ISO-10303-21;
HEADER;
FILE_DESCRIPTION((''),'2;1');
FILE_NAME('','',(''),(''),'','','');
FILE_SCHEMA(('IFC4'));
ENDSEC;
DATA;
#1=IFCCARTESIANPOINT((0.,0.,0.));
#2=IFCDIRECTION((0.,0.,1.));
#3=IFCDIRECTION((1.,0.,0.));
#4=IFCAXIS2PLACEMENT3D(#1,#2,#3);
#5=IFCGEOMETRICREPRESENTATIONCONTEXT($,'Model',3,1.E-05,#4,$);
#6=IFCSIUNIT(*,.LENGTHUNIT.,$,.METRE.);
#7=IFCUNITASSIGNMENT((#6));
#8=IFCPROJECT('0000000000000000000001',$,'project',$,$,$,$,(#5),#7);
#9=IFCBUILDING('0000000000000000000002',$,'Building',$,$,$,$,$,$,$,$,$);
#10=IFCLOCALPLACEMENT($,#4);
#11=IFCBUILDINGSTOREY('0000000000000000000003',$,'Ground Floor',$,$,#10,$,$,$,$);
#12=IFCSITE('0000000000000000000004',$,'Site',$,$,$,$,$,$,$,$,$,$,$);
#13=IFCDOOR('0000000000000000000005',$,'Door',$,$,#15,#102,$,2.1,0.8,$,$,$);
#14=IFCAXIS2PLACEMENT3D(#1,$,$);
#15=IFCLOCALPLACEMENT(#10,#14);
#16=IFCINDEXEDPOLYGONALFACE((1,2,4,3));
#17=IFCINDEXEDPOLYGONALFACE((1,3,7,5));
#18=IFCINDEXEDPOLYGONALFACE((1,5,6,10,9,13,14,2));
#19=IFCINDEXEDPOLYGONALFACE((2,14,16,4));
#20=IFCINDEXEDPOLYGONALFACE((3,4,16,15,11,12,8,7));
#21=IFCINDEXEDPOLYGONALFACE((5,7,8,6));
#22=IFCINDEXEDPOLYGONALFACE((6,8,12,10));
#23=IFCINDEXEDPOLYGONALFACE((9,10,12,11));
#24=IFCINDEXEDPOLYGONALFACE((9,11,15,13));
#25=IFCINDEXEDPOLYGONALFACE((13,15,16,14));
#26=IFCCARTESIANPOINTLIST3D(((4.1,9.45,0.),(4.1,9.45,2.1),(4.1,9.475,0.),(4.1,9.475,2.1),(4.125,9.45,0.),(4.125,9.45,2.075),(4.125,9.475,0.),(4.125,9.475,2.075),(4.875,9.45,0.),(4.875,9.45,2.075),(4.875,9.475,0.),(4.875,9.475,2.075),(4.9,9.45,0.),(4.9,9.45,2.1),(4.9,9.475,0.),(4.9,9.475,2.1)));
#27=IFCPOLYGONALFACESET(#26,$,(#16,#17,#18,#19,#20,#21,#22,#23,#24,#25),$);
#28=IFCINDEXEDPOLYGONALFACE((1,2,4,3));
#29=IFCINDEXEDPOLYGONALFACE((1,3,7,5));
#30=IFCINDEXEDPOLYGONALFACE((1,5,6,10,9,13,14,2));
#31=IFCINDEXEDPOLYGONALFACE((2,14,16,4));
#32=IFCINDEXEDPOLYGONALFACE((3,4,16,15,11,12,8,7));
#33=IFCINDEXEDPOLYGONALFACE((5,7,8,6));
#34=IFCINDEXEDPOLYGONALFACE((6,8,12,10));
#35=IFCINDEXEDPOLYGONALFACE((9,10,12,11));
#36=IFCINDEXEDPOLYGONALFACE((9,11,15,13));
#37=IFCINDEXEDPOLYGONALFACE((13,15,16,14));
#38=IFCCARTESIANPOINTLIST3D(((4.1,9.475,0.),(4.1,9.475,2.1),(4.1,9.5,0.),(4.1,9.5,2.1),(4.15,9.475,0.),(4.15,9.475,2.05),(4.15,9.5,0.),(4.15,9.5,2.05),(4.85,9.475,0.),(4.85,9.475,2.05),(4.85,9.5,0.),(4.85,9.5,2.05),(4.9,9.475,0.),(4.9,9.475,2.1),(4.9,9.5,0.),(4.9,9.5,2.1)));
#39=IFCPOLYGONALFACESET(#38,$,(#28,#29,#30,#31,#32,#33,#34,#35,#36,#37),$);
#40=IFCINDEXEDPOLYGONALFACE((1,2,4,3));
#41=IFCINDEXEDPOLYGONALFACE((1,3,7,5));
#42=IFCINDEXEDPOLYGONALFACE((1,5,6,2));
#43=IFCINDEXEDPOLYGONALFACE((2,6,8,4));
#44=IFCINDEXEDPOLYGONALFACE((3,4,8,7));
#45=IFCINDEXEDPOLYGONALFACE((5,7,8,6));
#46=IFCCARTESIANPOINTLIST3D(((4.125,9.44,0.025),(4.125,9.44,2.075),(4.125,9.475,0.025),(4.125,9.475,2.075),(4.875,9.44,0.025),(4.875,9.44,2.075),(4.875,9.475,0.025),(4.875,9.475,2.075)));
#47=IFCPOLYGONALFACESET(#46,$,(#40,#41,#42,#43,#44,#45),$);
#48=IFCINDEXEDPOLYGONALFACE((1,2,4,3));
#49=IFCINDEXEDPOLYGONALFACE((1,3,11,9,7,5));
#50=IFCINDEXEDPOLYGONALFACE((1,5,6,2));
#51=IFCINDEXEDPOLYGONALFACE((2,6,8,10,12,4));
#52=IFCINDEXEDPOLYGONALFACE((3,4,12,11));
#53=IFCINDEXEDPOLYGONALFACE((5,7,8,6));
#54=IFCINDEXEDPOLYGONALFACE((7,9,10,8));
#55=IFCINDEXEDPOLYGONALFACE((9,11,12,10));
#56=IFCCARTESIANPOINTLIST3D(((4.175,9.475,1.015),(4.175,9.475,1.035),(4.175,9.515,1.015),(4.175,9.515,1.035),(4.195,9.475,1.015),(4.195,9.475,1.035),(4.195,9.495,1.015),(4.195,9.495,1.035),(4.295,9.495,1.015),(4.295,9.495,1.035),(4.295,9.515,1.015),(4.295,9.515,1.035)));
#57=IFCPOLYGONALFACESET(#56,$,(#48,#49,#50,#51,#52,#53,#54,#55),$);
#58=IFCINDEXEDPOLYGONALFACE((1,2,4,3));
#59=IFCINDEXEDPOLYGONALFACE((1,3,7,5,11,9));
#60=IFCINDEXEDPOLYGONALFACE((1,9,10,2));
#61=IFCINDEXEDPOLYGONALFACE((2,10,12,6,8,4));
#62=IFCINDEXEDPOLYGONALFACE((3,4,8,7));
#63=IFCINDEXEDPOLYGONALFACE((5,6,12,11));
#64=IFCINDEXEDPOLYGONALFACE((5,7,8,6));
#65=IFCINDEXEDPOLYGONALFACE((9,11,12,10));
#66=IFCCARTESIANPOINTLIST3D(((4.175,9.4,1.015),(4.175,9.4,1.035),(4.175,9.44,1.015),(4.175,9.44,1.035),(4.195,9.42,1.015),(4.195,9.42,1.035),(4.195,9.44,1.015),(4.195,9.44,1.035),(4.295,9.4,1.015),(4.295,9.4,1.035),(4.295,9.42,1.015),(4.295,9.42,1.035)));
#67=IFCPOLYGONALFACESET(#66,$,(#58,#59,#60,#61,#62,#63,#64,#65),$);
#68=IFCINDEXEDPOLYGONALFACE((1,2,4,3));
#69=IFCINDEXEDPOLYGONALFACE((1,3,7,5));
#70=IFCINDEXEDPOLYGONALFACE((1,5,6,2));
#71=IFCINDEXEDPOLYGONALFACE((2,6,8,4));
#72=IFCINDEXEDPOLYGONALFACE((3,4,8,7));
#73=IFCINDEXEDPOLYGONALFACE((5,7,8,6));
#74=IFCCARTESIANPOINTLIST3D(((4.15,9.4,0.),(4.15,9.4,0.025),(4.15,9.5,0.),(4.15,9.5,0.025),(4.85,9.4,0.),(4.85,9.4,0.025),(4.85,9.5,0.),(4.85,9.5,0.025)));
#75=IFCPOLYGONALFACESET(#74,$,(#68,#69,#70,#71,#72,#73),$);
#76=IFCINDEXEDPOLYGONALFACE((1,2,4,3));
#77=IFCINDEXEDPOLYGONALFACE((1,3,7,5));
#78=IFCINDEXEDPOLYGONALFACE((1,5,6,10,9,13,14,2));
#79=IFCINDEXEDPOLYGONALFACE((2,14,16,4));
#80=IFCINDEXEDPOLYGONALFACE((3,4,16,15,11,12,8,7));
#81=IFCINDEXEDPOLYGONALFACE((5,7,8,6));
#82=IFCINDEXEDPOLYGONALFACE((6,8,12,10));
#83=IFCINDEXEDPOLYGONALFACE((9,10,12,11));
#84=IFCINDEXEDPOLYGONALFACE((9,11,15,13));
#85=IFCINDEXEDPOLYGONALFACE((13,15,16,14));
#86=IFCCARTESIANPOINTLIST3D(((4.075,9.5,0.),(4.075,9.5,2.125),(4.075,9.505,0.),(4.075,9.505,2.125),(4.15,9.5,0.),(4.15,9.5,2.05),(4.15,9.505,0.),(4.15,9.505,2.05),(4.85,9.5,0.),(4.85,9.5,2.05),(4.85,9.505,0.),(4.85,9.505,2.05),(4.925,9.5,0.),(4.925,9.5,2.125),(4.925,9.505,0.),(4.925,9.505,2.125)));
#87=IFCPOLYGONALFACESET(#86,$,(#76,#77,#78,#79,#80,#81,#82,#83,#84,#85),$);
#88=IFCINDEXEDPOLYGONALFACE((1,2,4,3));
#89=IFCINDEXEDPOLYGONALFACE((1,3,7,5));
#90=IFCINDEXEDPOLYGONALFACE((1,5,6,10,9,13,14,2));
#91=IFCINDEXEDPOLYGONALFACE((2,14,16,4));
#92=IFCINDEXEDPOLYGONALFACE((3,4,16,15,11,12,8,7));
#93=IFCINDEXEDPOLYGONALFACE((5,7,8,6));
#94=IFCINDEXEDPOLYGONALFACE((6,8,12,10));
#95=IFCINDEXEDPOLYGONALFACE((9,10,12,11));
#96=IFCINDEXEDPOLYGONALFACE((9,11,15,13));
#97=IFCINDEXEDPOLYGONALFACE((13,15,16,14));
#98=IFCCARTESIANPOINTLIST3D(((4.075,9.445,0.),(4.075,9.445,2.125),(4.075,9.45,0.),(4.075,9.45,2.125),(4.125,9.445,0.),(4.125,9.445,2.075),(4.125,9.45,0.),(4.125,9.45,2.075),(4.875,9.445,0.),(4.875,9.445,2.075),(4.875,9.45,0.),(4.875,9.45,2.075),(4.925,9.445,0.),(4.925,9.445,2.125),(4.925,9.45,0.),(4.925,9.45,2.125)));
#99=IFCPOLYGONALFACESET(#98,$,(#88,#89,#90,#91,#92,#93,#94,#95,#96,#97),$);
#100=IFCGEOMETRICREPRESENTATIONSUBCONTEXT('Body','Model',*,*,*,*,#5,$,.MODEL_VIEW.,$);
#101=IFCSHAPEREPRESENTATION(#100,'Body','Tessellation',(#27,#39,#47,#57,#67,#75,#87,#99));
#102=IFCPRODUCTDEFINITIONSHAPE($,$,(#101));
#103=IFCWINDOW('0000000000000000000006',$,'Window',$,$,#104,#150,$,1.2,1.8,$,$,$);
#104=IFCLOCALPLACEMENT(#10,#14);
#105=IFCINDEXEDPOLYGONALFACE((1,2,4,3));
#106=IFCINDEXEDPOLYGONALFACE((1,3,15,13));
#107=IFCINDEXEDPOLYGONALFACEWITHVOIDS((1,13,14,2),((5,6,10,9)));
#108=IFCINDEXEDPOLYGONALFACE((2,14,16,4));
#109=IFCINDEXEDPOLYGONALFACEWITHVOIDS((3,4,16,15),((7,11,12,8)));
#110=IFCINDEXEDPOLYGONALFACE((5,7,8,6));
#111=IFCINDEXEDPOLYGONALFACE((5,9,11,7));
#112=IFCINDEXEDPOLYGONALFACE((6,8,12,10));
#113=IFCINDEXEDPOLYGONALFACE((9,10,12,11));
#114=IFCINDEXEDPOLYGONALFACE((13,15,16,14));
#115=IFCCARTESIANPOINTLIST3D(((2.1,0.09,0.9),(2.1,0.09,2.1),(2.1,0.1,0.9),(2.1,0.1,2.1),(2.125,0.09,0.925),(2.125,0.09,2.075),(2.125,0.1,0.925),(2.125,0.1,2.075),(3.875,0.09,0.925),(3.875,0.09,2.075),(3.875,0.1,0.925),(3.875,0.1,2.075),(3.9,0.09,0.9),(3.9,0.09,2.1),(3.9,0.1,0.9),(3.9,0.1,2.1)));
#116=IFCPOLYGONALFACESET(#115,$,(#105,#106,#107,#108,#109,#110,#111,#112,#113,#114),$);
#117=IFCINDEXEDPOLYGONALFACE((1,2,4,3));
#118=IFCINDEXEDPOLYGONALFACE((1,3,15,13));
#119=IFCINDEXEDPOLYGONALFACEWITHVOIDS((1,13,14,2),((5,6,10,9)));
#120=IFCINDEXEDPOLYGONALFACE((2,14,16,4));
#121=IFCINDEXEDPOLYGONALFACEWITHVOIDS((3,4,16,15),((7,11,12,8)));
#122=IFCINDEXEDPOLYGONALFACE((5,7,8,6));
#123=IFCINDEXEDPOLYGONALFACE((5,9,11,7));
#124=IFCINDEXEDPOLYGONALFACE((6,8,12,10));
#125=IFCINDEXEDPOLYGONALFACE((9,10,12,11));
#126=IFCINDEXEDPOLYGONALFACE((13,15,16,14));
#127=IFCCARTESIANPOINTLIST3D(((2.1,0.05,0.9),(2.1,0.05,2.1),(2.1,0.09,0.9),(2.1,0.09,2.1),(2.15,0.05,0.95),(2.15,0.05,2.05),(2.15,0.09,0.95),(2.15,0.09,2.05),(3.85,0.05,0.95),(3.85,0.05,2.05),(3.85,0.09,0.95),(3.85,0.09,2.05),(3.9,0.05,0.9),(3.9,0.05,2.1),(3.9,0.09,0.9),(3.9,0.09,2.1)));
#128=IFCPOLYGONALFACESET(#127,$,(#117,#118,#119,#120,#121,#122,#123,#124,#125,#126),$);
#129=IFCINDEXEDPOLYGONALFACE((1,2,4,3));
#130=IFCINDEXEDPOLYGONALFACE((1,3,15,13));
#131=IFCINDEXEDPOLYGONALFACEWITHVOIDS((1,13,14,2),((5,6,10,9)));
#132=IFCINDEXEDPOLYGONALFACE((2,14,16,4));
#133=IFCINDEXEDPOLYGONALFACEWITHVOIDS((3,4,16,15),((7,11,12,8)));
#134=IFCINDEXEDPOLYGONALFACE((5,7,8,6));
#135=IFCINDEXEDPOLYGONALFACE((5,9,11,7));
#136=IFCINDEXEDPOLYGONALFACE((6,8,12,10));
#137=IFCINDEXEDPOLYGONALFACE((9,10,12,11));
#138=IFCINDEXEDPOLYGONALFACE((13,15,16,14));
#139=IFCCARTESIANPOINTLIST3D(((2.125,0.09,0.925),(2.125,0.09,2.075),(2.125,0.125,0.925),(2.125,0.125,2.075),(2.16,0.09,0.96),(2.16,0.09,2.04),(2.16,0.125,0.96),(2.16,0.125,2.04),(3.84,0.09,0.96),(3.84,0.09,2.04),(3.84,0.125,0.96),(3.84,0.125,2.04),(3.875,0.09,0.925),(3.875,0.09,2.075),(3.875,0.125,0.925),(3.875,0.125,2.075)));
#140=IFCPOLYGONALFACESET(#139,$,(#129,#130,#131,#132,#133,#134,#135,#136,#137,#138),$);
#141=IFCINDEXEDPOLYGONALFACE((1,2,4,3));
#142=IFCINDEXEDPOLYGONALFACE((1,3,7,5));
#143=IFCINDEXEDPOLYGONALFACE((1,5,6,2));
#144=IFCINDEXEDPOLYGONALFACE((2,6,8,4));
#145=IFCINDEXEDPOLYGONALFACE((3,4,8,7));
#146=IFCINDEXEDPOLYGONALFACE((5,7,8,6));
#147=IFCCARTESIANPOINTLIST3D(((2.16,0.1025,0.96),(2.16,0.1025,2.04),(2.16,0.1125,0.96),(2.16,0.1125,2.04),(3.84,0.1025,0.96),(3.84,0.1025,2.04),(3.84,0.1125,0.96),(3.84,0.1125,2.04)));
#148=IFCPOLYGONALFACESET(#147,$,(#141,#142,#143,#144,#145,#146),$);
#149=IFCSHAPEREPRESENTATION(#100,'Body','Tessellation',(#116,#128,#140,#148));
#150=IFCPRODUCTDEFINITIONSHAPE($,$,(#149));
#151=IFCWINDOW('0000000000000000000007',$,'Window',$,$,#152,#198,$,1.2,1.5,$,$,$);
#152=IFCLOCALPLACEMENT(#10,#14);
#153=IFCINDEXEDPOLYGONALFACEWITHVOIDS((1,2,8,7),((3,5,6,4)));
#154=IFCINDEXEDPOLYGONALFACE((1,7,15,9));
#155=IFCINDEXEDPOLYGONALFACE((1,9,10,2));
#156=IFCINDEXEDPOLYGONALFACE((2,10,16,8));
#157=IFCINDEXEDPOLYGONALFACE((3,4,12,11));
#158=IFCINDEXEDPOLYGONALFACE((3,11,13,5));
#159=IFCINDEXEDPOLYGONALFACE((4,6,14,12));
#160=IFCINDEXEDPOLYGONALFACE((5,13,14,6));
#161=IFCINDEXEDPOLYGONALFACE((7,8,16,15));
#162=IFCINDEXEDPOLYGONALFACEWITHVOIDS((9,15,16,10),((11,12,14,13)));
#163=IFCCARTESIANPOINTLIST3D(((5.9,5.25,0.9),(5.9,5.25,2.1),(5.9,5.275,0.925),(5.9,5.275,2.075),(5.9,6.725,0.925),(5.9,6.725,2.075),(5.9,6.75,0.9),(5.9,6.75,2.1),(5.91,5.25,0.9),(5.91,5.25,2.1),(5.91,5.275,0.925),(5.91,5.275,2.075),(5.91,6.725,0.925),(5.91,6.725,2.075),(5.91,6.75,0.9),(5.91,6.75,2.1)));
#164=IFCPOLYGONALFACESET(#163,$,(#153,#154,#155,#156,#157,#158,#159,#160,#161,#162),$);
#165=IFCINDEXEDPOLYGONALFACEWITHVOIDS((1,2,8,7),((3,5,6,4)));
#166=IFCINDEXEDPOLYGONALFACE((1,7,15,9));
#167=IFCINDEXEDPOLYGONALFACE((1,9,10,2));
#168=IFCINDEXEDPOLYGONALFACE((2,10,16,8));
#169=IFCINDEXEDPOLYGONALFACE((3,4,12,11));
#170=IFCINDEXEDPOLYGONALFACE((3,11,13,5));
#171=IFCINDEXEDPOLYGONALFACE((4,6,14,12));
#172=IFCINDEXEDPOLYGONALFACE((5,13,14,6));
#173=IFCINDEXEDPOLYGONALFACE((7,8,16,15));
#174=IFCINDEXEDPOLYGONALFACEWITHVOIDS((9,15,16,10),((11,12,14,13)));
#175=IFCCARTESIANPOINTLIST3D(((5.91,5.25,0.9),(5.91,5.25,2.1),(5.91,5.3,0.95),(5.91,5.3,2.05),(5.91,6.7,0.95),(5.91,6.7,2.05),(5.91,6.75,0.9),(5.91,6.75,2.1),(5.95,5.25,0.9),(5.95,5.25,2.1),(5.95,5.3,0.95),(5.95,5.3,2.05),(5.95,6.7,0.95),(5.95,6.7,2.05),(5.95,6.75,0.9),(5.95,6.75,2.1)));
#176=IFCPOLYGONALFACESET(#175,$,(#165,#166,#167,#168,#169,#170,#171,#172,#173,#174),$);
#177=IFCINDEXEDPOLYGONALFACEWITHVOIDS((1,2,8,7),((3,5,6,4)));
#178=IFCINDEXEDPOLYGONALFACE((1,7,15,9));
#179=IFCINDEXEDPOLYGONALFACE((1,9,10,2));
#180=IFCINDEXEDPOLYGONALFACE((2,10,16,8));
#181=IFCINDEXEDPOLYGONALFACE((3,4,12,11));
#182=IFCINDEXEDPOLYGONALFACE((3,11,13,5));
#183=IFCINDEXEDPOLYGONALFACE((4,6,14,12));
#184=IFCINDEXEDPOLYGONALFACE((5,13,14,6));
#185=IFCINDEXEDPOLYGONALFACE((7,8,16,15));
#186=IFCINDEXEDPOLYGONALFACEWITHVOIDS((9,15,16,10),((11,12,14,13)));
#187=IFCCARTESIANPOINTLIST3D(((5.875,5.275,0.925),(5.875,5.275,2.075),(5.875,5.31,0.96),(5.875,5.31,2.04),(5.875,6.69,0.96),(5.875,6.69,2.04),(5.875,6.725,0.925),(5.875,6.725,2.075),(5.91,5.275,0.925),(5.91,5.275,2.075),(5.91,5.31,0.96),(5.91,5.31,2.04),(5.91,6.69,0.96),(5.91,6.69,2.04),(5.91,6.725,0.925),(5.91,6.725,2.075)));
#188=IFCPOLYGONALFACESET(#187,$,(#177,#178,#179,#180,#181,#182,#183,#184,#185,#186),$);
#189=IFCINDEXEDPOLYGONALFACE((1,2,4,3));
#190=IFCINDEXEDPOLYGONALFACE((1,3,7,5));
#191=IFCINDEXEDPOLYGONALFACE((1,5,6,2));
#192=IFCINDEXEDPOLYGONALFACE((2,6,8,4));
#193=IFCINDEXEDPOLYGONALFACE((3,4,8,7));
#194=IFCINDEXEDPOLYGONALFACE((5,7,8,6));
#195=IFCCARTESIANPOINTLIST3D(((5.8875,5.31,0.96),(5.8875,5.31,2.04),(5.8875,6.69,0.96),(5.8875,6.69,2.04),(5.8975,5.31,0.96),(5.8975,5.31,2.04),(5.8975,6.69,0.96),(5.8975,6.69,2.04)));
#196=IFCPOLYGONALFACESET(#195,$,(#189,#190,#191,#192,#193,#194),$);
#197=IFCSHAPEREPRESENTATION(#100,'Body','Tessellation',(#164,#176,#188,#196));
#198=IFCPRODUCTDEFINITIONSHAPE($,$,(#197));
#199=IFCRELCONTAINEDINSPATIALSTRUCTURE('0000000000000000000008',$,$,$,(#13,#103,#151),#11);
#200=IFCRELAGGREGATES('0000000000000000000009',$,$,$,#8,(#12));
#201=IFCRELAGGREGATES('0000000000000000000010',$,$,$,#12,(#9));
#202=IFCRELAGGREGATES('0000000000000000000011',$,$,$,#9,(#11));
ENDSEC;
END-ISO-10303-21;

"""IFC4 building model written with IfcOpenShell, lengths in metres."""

from ifc_helpers import new_model, si_unit, frame, origin_with_axes, place, context, subcontext, project, spatial, line, indexed_curve, outline, extrude, element, save


model = new_model("IFC4")

# Units and contexts
model_context = context("Model", 3, precision=1e-05, world=origin_with_axes())
body_context = subcontext(model_context, "Body", "Model", "MODEL_VIEW")
ifc_project = project(units=[si_unit("LENGTHUNIT", "METRE")], contexts=[model_context])

# Site, building, storey
site = spatial("IfcSite", under=ifc_project, Name="Site")
building = spatial("IfcBuilding", under=site, Name="Building")
storey_placement = place(None, origin_with_axes())
storey = spatial("IfcBuildingStorey", under=building, at=storey_placement, Name="Ground Floor")

# Door
door_1_placement = place(storey_placement, frame((4.9, 9.5, 0.0), z_axis=(0.0, 0.0, 1.0), x_axis=(-1.0, 0.0, 0.0)))
element("IfcDoor", 1, at=door_1_placement, inside=storey, Name="Door", OverallHeight=2.1, OverallWidth=0.8, context=body_context, shape_type="SweptSolid", body=[
    extrude(outline(indexed_curve([(0.0, 0.0), (0.0, 2.1), (0.8, 2.1), (0.8, 0.0), (0.775, 0.0), (0.775, 2.075), (0.025, 2.075), (0.025, 0.0)], segments=[line(1, 2, 3, 4, 5, 6, 7, 8, 1)])), frame((0.0, 0.025, 0.0), z_axis=(0.0, -1.0, 0.0), x_axis=(1.0, 0.0, 0.0)), (0.0, 0.0, -1.0), 0.025),
    extrude(outline(indexed_curve([(0.0, 0.0), (0.0, 2.1), (0.8, 2.1), (0.8, 0.0), (0.75, 0.0), (0.75, 2.05), (0.05, 2.05), (0.05, 0.0)], segments=[line(1, 2, 3, 4, 5, 6, 7, 8, 1)])), frame((0.0, 0.0, 0.0), z_axis=(0.0, -1.0, 0.0), x_axis=(1.0, 0.0, 0.0)), (0.0, 0.0, -1.0), 0.025),
    extrude(outline(indexed_curve([(0.0, 0.0), (0.75, 0.0), (0.75, 0.035), (0.0, 0.035)], segments=[line(1, 2, 3, 4, 1)])), frame((0.025, 0.025, 0.025), z_axis=(0.0, 0.0, 1.0), x_axis=(1.0, 0.0, 0.0)), (0.0, 0.0, 1.0), 2.05),
    extrude(outline(indexed_curve([(0.0, 0.0), (0.0, -0.04), (-0.12, -0.04), (-0.12, -0.02), (-0.02, -0.02), (-0.02, 0.0)], segments=[line(1, 2, 3, 4, 5, 6, 1)])), frame((0.725, 0.025, 1.015), z_axis=(0.0, 0.0, 1.0), x_axis=(1.0, 0.0, 0.0)), (0.0, 0.0, 1.0), 0.02),
    extrude(outline(indexed_curve([(0.0, 0.0), (0.0, 0.04), (-0.12, 0.04), (-0.12, 0.02), (-0.02, 0.02), (-0.02, 0.0)], segments=[line(1, 2, 3, 4, 5, 6, 1)])), frame((0.725, 0.06, 1.015), z_axis=(0.0, 0.0, 1.0), x_axis=(1.0, 0.0, 0.0)), (0.0, 0.0, 1.0), 0.02),
    extrude(outline(indexed_curve([(0.0, 0.0), (0.7, 0.0), (0.7, 0.1), (0.0, 0.1)], segments=[line(1, 2, 3, 4, 1)])), frame((0.05, 0.0, 0.0), z_axis=(0.0, 0.0, 1.0), x_axis=(1.0, 0.0, 0.0)), (0.0, 0.0, 1.0), 0.025),
    extrude(outline(indexed_curve([(0.0, 0.0), (0.0, 2.125), (0.85, 2.125), (0.85, 0.0), (0.775, 0.0), (0.775, 2.05), (0.075, 2.05), (0.075, 0.0)], segments=[line(1, 2, 3, 4, 5, 6, 7, 8, 1)])), frame((-0.025, -0.005, 0.0), z_axis=(0.0, -1.0, 0.0), x_axis=(1.0, 0.0, 0.0)), (0.0, 0.0, -1.0), 0.005),
    extrude(outline(indexed_curve([(0.0, 0.0), (0.0, 2.125), (0.85, 2.125), (0.85, 0.0), (0.8, 0.0), (0.8, 2.075), (0.05, 2.075), (0.05, 0.0)], segments=[line(1, 2, 3, 4, 5, 6, 7, 8, 1)])), frame((-0.025, 0.05, 0.0), z_axis=(0.0, -1.0, 0.0), x_axis=(1.0, 0.0, 0.0)), (0.0, 0.0, -1.0), 0.005),
])

# Windows
window_1_placement = place(storey_placement, frame((2.1, 0.0, 0.9), z_axis=(0.0, 0.0, 1.0), x_axis=(1.0, 0.0, 0.0)))
element("IfcWindow", 2, at=window_1_placement, inside=storey, Name="Window", OverallHeight=1.2, OverallWidth=1.8, context=body_context, shape_type="SweptSolid", body=[
    extrude(outline(indexed_curve([(0.0, 0.0), (1.8, 0.0), (1.8, 1.2), (0.0, 1.2)], segments=[line(1, 2, 3, 4, 1)]), holes=[indexed_curve([(0.025, 0.025), (1.775, 0.025), (1.775, 1.175), (0.025, 1.175)], segments=[line(1, 2, 3, 4, 1)])]), frame((0.0, 0.09, 0.0), z_axis=(0.0, -1.0, 0.0), x_axis=(1.0, 0.0, 0.0)), (0.0, 0.0, -1.0), 0.01),
    extrude(outline(indexed_curve([(0.0, 0.0), (1.8, 0.0), (1.8, 1.2), (0.0, 1.2)], segments=[line(1, 2, 3, 4, 1)]), holes=[indexed_curve([(0.05, 0.05), (1.75, 0.05), (1.75, 1.15), (0.05, 1.15)], segments=[line(1, 2, 3, 4, 1)])]), frame((0.0, 0.05, 0.0), z_axis=(0.0, -1.0, 0.0), x_axis=(1.0, 0.0, 0.0)), (0.0, 0.0, -1.0), 0.04),
    extrude(outline(indexed_curve([(0.0, 0.0), (1.75, 0.0), (1.75, 1.15), (0.0, 1.15)], segments=[line(1, 2, 3, 4, 1)]), holes=[indexed_curve([(0.035, 0.035), (1.715, 0.035), (1.715, 1.115), (0.035, 1.115)], segments=[line(1, 2, 3, 4, 1)])]), frame((0.025, 0.09, 0.025), z_axis=(0.0, -1.0, 0.0), x_axis=(1.0, 0.0, 0.0)), (0.0, 0.0, -1.0), 0.035),
    extrude(outline(indexed_curve([(0.035, 0.035), (1.715, 0.035), (1.715, 1.115), (0.035, 1.115)], segments=[line(1, 2, 3, 4, 1)])), frame((0.025, 0.1025, 0.025), z_axis=(0.0, -1.0, 0.0), x_axis=(1.0, 0.0, 0.0)), (0.0, 0.0, -1.0), 0.01),
])
window_2_placement = place(storey_placement, frame((6.0, 5.25, 0.9), z_axis=(0.0, 0.0, 1.0), x_axis=(0.0, 1.0, 0.0)))
element("IfcWindow", 3, at=window_2_placement, inside=storey, Name="Window", OverallHeight=1.2, OverallWidth=1.5, context=body_context, shape_type="SweptSolid", body=[
    extrude(outline(indexed_curve([(0.0, 0.0), (1.5, 0.0), (1.5, 1.2), (0.0, 1.2)], segments=[line(1, 2, 3, 4, 1)]), holes=[indexed_curve([(0.025, 0.025), (1.475, 0.025), (1.475, 1.175), (0.025, 1.175)], segments=[line(1, 2, 3, 4, 1)])]), frame((0.0, 0.09, 0.0), z_axis=(0.0, -1.0, 0.0), x_axis=(1.0, 0.0, 0.0)), (0.0, 0.0, -1.0), 0.01),
    extrude(outline(indexed_curve([(0.0, 0.0), (1.5, 0.0), (1.5, 1.2), (0.0, 1.2)], segments=[line(1, 2, 3, 4, 1)]), holes=[indexed_curve([(0.05, 0.05), (1.45, 0.05), (1.45, 1.15), (0.05, 1.15)], segments=[line(1, 2, 3, 4, 1)])]), frame((0.0, 0.05, 0.0), z_axis=(0.0, -1.0, 0.0), x_axis=(1.0, 0.0, 0.0)), (0.0, 0.0, -1.0), 0.04),
    extrude(outline(indexed_curve([(0.0, 0.0), (1.45, 0.0), (1.45, 1.15), (0.0, 1.15)], segments=[line(1, 2, 3, 4, 1)]), holes=[indexed_curve([(0.035, 0.035), (1.415, 0.035), (1.415, 1.115), (0.035, 1.115)], segments=[line(1, 2, 3, 4, 1)])]), frame((0.025, 0.09, 0.025), z_axis=(0.0, -1.0, 0.0), x_axis=(1.0, 0.0, 0.0)), (0.0, 0.0, -1.0), 0.035),
    extrude(outline(indexed_curve([(0.035, 0.035), (1.415, 0.035), (1.415, 1.115), (0.035, 1.115)], segments=[line(1, 2, 3, 4, 1)])), frame((0.025, 0.1025, 0.025), z_axis=(0.0, -1.0, 0.0), x_axis=(1.0, 0.0, 0.0)), (0.0, 0.0, -1.0), 0.01),
])

save(model, "model.ifc")
